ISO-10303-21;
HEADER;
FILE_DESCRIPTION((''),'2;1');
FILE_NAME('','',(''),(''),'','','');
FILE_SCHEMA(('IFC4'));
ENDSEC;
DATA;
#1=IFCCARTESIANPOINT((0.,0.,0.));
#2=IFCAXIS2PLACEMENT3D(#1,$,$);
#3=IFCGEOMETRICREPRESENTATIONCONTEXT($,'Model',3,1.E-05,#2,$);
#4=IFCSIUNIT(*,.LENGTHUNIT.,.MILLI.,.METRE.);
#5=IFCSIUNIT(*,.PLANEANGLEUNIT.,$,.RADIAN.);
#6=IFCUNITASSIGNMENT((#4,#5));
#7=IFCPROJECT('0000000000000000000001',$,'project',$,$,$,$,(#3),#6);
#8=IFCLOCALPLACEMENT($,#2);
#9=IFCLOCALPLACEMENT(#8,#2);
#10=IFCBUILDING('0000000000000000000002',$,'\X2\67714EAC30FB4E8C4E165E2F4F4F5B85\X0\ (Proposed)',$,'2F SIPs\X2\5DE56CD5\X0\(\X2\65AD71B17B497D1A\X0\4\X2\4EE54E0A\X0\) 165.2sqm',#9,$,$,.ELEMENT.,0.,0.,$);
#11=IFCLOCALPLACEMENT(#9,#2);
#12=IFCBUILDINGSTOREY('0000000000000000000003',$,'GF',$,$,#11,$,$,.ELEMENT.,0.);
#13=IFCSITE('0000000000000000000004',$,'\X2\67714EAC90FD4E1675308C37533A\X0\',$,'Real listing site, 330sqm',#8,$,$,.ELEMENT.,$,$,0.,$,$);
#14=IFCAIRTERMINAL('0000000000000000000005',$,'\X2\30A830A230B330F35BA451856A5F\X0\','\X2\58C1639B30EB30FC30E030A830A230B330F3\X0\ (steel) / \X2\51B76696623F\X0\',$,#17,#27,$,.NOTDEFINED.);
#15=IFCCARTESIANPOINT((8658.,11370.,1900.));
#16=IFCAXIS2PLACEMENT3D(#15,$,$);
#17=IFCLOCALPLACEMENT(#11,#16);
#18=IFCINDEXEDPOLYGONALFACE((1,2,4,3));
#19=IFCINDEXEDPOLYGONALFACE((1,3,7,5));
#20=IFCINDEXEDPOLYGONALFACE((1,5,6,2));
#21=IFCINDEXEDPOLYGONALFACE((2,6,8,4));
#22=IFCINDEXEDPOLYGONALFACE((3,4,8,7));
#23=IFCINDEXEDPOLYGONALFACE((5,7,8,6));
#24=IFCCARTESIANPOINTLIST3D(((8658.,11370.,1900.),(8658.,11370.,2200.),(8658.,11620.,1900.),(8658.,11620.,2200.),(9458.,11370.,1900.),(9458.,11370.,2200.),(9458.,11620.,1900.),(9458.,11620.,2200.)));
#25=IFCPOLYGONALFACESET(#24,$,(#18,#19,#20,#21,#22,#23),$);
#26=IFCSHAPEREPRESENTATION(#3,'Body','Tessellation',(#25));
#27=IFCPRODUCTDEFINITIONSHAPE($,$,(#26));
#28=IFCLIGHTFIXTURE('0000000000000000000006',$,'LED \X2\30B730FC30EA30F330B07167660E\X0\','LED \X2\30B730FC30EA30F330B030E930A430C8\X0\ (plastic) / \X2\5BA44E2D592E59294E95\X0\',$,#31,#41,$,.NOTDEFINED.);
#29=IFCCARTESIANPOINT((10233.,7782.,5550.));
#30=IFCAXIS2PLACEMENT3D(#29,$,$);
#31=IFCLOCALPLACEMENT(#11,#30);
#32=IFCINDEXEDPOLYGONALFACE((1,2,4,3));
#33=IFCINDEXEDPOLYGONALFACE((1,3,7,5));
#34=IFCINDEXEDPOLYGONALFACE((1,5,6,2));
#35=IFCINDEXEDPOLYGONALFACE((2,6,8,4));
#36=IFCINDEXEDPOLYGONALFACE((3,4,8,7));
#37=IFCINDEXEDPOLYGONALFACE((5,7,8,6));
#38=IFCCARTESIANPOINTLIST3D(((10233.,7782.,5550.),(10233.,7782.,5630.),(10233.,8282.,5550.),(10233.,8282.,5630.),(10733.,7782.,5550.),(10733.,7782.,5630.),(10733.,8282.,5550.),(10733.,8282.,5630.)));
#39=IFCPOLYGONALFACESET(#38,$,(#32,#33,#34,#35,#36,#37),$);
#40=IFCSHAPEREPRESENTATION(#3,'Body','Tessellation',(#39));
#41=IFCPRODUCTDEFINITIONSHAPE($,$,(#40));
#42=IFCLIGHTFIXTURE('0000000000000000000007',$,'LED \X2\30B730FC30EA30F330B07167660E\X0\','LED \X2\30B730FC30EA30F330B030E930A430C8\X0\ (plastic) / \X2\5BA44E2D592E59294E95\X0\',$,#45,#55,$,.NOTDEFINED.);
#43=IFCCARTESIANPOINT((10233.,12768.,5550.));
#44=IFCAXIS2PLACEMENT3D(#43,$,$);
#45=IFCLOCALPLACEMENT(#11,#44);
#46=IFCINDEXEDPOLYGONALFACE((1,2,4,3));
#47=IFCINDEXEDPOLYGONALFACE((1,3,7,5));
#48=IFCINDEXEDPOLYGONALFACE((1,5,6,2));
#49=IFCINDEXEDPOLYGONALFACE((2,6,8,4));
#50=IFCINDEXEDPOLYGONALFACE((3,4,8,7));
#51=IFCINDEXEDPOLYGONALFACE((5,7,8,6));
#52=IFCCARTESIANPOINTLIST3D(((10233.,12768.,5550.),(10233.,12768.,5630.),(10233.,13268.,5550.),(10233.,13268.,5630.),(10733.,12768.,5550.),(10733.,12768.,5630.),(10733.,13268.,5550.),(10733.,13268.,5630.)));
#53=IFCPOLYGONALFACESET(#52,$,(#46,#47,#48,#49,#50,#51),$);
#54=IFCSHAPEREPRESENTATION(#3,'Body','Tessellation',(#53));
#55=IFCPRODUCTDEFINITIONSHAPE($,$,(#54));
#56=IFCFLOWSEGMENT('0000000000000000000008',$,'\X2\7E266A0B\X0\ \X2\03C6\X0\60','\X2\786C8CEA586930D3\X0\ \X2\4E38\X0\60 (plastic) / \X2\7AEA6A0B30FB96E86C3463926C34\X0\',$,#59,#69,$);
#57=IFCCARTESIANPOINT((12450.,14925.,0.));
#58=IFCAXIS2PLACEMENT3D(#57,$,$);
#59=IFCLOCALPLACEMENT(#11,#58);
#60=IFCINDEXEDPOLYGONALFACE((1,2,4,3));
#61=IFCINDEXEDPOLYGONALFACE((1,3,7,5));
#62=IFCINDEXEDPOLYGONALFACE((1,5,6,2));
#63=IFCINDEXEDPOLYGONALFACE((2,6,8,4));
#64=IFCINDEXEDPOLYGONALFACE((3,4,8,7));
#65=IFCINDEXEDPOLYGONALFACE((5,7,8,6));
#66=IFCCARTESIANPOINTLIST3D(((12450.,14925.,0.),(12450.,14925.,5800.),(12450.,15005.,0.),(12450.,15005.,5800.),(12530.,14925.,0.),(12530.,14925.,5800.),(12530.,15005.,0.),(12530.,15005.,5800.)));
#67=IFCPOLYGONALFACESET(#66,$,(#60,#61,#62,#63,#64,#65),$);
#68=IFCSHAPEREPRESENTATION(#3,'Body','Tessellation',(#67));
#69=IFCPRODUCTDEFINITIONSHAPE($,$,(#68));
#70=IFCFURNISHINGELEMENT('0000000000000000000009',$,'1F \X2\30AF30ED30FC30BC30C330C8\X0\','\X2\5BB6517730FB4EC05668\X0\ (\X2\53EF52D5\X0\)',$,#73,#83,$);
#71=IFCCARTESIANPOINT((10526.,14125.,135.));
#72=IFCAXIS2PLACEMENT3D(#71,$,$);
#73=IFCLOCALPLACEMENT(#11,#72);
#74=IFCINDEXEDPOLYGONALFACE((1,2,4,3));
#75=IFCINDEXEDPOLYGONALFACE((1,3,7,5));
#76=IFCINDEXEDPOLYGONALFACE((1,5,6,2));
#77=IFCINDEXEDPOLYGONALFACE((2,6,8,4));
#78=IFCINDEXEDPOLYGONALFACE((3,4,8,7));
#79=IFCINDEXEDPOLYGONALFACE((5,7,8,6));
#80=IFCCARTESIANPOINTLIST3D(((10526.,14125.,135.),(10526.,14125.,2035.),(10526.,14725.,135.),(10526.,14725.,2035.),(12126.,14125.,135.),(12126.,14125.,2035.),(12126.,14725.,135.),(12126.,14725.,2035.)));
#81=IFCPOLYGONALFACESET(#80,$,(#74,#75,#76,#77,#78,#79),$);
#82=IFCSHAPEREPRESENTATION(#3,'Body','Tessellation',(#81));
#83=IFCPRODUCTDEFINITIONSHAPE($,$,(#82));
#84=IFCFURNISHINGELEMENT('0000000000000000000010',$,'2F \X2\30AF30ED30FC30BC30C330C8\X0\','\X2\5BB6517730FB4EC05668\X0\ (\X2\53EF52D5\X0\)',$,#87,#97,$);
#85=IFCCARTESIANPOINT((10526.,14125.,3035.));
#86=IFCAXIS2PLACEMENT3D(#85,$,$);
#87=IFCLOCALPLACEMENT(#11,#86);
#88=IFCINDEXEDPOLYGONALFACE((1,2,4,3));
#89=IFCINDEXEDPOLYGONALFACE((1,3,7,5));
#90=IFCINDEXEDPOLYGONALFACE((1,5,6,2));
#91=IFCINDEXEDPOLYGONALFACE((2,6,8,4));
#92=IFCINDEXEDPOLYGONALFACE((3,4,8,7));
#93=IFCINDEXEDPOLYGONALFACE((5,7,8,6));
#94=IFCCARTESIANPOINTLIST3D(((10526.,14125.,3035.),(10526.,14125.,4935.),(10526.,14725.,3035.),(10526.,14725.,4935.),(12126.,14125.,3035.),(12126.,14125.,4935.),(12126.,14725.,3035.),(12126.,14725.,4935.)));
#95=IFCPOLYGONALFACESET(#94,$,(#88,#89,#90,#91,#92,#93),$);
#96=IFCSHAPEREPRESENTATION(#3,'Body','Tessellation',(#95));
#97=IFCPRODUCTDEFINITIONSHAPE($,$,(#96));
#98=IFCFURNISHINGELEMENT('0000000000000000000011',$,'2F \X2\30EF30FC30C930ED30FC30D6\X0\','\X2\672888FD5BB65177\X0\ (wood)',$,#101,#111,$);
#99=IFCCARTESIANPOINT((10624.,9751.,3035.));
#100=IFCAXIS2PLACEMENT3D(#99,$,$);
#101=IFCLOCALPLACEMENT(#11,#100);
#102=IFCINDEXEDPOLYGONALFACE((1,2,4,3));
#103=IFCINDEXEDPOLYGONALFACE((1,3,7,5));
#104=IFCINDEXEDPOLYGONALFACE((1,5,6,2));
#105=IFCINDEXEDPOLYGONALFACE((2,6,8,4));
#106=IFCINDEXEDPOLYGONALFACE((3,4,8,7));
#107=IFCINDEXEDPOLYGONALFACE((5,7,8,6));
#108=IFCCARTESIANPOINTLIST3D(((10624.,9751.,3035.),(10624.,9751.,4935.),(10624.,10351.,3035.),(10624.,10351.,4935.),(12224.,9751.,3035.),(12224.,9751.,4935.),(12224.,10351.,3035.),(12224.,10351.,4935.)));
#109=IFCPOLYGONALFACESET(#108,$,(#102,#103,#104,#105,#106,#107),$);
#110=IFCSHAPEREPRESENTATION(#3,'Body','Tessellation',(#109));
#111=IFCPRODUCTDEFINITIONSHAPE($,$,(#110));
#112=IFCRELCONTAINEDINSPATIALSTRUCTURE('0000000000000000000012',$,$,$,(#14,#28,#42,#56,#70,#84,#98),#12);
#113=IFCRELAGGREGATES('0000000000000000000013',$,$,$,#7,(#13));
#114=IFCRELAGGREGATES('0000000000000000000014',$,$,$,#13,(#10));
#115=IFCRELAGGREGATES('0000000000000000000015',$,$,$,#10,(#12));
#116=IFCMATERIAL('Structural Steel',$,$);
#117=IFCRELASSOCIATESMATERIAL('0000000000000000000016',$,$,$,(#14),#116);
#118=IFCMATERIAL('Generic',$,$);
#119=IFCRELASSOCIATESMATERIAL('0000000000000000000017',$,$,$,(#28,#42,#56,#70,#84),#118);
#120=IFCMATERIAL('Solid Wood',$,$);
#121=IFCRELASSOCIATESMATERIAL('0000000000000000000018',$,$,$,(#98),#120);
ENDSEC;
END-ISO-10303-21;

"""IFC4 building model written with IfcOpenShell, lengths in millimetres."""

from ifc_helpers import new_model, si_unit, frame, frame_2d, origin, place, context, project, spatial, rectangle, extrude, material, element, save


model = new_model("IFC4")

# Units and contexts
model_context = context("Model", 3, precision=1e-05, world=origin())
ifc_project = project(units=[si_unit("LENGTHUNIT", "METRE", prefix="MILLI"), si_unit("PLANEANGLEUNIT", "RADIAN")], contexts=[model_context])

# Site, building, storey
site_placement = place(None, origin())
site = spatial("IfcSite", under=ifc_project, at=site_placement, Name="東京都世田谷区", ObjectType="Real listing site, 330sqm", CompositionType="ELEMENT", RefElevation=0.0)
building_placement = place(site_placement, origin())
building = spatial("IfcBuilding", under=site, at=building_placement, Name="東京・二世帯住宅 (Proposed)", ObjectType="2F SIPs工法(断熱等級4以上) 165.2sqm", CompositionType="ELEMENT", ElevationOfRefHeight=0.0, ElevationOfTerrain=0.0)
storey_placement = place(building_placement, origin())
storey = spatial("IfcBuildingStorey", under=building, at=storey_placement, Name="GF", CompositionType="ELEMENT", Elevation=0.0)

# Shared definitions
ifc_material_1 = material(Name="Solid Wood")

# Shared definitions
ifc_material_2 = material(Name="Structural Steel")

# Shared definitions
ifc_material_3 = material(Name="Generic")

# Air terminal
air_terminal_placement = place(storey_placement, frame((8658.0, 11370.0, 1900.0)))
element("IfcAirTerminal", 1, at=air_terminal_placement, inside=storey, material=ifc_material_2, Name="エアコン室内機", Description="壁掛ルームエアコン (steel) / 冷暖房", PredefinedType="NOTDEFINED", context=model_context, shape_type="SweptSolid", body=[
    extrude(rectangle(XDim=800.0, YDim=250.0, at=frame_2d((400.0, 125.0))), frame((8658.0, 11370.0, 1900.0)), (0.0, 0.0, 1.0), 300.0),
])

# Light fixtures
light_fixture_1_placement = place(storey_placement, frame((10233.0, 7782.0, 5550.0)))
element("IfcLightFixture", 2, at=light_fixture_1_placement, inside=storey, material=ifc_material_3, Name="LED シーリング照明", Description="LED シーリングライト (plastic) / 室中央天井", PredefinedType="NOTDEFINED", context=model_context, shape_type="SweptSolid", body=[
    extrude(rectangle(XDim=500.0, YDim=500.0, at=frame_2d((250.0, 250.0))), frame((10233.0, 7782.0, 5550.0)), (0.0, 0.0, 1.0), 80.0),
])
light_fixture_2_placement = place(storey_placement, frame((10233.0, 12768.0, 5550.0)))
element("IfcLightFixture", 3, at=light_fixture_2_placement, inside=storey, material=ifc_material_3, Name="LED シーリング照明", Description="LED シーリングライト (plastic) / 室中央天井", PredefinedType="NOTDEFINED", context=model_context, shape_type="SweptSolid", body=[
    extrude(rectangle(XDim=500.0, YDim=500.0, at=frame_2d((250.0, 250.0))), frame((10233.0, 12768.0, 5550.0)), (0.0, 0.0, 1.0), 80.0),
])

# Flow segment
flow_segment_placement = place(storey_placement, frame((12450.0, 14925.0, 0.0)))
element("IfcFlowSegment", 4, at=flow_segment_placement, inside=storey, material=ifc_material_3, Name="縦樋 φ60", Description="硬質塩ビ 丸60 (plastic) / 竪樋・雨水排水", context=model_context, shape_type="SweptSolid", body=[
    extrude(rectangle(XDim=80.0, YDim=80.0, at=frame_2d((40.0, 40.0))), frame((12450.0, 14925.0, 0.0)), (0.0, 0.0, 1.0), 5800.0),
])

# Furnishing elements
furnishing_1_placement = place(storey_placement, frame((10526.0, 14125.0, 135.0)))
element("IfcFurnishingElement", 5, at=furnishing_1_placement, inside=storey, material=ifc_material_3, Name="1F クローゼット", Description="家具・什器 (可動)", context=model_context, shape_type="SweptSolid", body=[
    extrude(rectangle(XDim=1600.0, YDim=600.0, at=frame_2d((800.0, 300.0))), frame((10526.0, 14125.0, 135.0)), (0.0, 0.0, 1.0), 1900.0),
])
furnishing_2_placement = place(storey_placement, frame((10526.0, 14125.0, 3035.0)))
element("IfcFurnishingElement", 6, at=furnishing_2_placement, inside=storey, material=ifc_material_3, Name="2F クローゼット", Description="家具・什器 (可動)", context=model_context, shape_type="SweptSolid", body=[
    extrude(rectangle(XDim=1600.0, YDim=600.0, at=frame_2d((800.0, 300.0))), frame((10526.0, 14125.0, 3035.0)), (0.0, 0.0, 1.0), 1900.0),
])
furnishing_3_placement = place(storey_placement, frame((10624.0, 9751.0, 3035.0)))
element("IfcFurnishingElement", 7, at=furnishing_3_placement, inside=storey, material=ifc_material_1, Name="2F ワードローブ", Description="木製家具 (wood)", context=model_context, shape_type="SweptSolid", body=[
    extrude(rectangle(XDim=1600.0, YDim=600.0, at=frame_2d((800.0, 300.0))), frame((10624.0, 9751.0, 3035.0)), (0.0, 0.0, 1.0), 1900.0),
])

save(model, "model.ifc")
